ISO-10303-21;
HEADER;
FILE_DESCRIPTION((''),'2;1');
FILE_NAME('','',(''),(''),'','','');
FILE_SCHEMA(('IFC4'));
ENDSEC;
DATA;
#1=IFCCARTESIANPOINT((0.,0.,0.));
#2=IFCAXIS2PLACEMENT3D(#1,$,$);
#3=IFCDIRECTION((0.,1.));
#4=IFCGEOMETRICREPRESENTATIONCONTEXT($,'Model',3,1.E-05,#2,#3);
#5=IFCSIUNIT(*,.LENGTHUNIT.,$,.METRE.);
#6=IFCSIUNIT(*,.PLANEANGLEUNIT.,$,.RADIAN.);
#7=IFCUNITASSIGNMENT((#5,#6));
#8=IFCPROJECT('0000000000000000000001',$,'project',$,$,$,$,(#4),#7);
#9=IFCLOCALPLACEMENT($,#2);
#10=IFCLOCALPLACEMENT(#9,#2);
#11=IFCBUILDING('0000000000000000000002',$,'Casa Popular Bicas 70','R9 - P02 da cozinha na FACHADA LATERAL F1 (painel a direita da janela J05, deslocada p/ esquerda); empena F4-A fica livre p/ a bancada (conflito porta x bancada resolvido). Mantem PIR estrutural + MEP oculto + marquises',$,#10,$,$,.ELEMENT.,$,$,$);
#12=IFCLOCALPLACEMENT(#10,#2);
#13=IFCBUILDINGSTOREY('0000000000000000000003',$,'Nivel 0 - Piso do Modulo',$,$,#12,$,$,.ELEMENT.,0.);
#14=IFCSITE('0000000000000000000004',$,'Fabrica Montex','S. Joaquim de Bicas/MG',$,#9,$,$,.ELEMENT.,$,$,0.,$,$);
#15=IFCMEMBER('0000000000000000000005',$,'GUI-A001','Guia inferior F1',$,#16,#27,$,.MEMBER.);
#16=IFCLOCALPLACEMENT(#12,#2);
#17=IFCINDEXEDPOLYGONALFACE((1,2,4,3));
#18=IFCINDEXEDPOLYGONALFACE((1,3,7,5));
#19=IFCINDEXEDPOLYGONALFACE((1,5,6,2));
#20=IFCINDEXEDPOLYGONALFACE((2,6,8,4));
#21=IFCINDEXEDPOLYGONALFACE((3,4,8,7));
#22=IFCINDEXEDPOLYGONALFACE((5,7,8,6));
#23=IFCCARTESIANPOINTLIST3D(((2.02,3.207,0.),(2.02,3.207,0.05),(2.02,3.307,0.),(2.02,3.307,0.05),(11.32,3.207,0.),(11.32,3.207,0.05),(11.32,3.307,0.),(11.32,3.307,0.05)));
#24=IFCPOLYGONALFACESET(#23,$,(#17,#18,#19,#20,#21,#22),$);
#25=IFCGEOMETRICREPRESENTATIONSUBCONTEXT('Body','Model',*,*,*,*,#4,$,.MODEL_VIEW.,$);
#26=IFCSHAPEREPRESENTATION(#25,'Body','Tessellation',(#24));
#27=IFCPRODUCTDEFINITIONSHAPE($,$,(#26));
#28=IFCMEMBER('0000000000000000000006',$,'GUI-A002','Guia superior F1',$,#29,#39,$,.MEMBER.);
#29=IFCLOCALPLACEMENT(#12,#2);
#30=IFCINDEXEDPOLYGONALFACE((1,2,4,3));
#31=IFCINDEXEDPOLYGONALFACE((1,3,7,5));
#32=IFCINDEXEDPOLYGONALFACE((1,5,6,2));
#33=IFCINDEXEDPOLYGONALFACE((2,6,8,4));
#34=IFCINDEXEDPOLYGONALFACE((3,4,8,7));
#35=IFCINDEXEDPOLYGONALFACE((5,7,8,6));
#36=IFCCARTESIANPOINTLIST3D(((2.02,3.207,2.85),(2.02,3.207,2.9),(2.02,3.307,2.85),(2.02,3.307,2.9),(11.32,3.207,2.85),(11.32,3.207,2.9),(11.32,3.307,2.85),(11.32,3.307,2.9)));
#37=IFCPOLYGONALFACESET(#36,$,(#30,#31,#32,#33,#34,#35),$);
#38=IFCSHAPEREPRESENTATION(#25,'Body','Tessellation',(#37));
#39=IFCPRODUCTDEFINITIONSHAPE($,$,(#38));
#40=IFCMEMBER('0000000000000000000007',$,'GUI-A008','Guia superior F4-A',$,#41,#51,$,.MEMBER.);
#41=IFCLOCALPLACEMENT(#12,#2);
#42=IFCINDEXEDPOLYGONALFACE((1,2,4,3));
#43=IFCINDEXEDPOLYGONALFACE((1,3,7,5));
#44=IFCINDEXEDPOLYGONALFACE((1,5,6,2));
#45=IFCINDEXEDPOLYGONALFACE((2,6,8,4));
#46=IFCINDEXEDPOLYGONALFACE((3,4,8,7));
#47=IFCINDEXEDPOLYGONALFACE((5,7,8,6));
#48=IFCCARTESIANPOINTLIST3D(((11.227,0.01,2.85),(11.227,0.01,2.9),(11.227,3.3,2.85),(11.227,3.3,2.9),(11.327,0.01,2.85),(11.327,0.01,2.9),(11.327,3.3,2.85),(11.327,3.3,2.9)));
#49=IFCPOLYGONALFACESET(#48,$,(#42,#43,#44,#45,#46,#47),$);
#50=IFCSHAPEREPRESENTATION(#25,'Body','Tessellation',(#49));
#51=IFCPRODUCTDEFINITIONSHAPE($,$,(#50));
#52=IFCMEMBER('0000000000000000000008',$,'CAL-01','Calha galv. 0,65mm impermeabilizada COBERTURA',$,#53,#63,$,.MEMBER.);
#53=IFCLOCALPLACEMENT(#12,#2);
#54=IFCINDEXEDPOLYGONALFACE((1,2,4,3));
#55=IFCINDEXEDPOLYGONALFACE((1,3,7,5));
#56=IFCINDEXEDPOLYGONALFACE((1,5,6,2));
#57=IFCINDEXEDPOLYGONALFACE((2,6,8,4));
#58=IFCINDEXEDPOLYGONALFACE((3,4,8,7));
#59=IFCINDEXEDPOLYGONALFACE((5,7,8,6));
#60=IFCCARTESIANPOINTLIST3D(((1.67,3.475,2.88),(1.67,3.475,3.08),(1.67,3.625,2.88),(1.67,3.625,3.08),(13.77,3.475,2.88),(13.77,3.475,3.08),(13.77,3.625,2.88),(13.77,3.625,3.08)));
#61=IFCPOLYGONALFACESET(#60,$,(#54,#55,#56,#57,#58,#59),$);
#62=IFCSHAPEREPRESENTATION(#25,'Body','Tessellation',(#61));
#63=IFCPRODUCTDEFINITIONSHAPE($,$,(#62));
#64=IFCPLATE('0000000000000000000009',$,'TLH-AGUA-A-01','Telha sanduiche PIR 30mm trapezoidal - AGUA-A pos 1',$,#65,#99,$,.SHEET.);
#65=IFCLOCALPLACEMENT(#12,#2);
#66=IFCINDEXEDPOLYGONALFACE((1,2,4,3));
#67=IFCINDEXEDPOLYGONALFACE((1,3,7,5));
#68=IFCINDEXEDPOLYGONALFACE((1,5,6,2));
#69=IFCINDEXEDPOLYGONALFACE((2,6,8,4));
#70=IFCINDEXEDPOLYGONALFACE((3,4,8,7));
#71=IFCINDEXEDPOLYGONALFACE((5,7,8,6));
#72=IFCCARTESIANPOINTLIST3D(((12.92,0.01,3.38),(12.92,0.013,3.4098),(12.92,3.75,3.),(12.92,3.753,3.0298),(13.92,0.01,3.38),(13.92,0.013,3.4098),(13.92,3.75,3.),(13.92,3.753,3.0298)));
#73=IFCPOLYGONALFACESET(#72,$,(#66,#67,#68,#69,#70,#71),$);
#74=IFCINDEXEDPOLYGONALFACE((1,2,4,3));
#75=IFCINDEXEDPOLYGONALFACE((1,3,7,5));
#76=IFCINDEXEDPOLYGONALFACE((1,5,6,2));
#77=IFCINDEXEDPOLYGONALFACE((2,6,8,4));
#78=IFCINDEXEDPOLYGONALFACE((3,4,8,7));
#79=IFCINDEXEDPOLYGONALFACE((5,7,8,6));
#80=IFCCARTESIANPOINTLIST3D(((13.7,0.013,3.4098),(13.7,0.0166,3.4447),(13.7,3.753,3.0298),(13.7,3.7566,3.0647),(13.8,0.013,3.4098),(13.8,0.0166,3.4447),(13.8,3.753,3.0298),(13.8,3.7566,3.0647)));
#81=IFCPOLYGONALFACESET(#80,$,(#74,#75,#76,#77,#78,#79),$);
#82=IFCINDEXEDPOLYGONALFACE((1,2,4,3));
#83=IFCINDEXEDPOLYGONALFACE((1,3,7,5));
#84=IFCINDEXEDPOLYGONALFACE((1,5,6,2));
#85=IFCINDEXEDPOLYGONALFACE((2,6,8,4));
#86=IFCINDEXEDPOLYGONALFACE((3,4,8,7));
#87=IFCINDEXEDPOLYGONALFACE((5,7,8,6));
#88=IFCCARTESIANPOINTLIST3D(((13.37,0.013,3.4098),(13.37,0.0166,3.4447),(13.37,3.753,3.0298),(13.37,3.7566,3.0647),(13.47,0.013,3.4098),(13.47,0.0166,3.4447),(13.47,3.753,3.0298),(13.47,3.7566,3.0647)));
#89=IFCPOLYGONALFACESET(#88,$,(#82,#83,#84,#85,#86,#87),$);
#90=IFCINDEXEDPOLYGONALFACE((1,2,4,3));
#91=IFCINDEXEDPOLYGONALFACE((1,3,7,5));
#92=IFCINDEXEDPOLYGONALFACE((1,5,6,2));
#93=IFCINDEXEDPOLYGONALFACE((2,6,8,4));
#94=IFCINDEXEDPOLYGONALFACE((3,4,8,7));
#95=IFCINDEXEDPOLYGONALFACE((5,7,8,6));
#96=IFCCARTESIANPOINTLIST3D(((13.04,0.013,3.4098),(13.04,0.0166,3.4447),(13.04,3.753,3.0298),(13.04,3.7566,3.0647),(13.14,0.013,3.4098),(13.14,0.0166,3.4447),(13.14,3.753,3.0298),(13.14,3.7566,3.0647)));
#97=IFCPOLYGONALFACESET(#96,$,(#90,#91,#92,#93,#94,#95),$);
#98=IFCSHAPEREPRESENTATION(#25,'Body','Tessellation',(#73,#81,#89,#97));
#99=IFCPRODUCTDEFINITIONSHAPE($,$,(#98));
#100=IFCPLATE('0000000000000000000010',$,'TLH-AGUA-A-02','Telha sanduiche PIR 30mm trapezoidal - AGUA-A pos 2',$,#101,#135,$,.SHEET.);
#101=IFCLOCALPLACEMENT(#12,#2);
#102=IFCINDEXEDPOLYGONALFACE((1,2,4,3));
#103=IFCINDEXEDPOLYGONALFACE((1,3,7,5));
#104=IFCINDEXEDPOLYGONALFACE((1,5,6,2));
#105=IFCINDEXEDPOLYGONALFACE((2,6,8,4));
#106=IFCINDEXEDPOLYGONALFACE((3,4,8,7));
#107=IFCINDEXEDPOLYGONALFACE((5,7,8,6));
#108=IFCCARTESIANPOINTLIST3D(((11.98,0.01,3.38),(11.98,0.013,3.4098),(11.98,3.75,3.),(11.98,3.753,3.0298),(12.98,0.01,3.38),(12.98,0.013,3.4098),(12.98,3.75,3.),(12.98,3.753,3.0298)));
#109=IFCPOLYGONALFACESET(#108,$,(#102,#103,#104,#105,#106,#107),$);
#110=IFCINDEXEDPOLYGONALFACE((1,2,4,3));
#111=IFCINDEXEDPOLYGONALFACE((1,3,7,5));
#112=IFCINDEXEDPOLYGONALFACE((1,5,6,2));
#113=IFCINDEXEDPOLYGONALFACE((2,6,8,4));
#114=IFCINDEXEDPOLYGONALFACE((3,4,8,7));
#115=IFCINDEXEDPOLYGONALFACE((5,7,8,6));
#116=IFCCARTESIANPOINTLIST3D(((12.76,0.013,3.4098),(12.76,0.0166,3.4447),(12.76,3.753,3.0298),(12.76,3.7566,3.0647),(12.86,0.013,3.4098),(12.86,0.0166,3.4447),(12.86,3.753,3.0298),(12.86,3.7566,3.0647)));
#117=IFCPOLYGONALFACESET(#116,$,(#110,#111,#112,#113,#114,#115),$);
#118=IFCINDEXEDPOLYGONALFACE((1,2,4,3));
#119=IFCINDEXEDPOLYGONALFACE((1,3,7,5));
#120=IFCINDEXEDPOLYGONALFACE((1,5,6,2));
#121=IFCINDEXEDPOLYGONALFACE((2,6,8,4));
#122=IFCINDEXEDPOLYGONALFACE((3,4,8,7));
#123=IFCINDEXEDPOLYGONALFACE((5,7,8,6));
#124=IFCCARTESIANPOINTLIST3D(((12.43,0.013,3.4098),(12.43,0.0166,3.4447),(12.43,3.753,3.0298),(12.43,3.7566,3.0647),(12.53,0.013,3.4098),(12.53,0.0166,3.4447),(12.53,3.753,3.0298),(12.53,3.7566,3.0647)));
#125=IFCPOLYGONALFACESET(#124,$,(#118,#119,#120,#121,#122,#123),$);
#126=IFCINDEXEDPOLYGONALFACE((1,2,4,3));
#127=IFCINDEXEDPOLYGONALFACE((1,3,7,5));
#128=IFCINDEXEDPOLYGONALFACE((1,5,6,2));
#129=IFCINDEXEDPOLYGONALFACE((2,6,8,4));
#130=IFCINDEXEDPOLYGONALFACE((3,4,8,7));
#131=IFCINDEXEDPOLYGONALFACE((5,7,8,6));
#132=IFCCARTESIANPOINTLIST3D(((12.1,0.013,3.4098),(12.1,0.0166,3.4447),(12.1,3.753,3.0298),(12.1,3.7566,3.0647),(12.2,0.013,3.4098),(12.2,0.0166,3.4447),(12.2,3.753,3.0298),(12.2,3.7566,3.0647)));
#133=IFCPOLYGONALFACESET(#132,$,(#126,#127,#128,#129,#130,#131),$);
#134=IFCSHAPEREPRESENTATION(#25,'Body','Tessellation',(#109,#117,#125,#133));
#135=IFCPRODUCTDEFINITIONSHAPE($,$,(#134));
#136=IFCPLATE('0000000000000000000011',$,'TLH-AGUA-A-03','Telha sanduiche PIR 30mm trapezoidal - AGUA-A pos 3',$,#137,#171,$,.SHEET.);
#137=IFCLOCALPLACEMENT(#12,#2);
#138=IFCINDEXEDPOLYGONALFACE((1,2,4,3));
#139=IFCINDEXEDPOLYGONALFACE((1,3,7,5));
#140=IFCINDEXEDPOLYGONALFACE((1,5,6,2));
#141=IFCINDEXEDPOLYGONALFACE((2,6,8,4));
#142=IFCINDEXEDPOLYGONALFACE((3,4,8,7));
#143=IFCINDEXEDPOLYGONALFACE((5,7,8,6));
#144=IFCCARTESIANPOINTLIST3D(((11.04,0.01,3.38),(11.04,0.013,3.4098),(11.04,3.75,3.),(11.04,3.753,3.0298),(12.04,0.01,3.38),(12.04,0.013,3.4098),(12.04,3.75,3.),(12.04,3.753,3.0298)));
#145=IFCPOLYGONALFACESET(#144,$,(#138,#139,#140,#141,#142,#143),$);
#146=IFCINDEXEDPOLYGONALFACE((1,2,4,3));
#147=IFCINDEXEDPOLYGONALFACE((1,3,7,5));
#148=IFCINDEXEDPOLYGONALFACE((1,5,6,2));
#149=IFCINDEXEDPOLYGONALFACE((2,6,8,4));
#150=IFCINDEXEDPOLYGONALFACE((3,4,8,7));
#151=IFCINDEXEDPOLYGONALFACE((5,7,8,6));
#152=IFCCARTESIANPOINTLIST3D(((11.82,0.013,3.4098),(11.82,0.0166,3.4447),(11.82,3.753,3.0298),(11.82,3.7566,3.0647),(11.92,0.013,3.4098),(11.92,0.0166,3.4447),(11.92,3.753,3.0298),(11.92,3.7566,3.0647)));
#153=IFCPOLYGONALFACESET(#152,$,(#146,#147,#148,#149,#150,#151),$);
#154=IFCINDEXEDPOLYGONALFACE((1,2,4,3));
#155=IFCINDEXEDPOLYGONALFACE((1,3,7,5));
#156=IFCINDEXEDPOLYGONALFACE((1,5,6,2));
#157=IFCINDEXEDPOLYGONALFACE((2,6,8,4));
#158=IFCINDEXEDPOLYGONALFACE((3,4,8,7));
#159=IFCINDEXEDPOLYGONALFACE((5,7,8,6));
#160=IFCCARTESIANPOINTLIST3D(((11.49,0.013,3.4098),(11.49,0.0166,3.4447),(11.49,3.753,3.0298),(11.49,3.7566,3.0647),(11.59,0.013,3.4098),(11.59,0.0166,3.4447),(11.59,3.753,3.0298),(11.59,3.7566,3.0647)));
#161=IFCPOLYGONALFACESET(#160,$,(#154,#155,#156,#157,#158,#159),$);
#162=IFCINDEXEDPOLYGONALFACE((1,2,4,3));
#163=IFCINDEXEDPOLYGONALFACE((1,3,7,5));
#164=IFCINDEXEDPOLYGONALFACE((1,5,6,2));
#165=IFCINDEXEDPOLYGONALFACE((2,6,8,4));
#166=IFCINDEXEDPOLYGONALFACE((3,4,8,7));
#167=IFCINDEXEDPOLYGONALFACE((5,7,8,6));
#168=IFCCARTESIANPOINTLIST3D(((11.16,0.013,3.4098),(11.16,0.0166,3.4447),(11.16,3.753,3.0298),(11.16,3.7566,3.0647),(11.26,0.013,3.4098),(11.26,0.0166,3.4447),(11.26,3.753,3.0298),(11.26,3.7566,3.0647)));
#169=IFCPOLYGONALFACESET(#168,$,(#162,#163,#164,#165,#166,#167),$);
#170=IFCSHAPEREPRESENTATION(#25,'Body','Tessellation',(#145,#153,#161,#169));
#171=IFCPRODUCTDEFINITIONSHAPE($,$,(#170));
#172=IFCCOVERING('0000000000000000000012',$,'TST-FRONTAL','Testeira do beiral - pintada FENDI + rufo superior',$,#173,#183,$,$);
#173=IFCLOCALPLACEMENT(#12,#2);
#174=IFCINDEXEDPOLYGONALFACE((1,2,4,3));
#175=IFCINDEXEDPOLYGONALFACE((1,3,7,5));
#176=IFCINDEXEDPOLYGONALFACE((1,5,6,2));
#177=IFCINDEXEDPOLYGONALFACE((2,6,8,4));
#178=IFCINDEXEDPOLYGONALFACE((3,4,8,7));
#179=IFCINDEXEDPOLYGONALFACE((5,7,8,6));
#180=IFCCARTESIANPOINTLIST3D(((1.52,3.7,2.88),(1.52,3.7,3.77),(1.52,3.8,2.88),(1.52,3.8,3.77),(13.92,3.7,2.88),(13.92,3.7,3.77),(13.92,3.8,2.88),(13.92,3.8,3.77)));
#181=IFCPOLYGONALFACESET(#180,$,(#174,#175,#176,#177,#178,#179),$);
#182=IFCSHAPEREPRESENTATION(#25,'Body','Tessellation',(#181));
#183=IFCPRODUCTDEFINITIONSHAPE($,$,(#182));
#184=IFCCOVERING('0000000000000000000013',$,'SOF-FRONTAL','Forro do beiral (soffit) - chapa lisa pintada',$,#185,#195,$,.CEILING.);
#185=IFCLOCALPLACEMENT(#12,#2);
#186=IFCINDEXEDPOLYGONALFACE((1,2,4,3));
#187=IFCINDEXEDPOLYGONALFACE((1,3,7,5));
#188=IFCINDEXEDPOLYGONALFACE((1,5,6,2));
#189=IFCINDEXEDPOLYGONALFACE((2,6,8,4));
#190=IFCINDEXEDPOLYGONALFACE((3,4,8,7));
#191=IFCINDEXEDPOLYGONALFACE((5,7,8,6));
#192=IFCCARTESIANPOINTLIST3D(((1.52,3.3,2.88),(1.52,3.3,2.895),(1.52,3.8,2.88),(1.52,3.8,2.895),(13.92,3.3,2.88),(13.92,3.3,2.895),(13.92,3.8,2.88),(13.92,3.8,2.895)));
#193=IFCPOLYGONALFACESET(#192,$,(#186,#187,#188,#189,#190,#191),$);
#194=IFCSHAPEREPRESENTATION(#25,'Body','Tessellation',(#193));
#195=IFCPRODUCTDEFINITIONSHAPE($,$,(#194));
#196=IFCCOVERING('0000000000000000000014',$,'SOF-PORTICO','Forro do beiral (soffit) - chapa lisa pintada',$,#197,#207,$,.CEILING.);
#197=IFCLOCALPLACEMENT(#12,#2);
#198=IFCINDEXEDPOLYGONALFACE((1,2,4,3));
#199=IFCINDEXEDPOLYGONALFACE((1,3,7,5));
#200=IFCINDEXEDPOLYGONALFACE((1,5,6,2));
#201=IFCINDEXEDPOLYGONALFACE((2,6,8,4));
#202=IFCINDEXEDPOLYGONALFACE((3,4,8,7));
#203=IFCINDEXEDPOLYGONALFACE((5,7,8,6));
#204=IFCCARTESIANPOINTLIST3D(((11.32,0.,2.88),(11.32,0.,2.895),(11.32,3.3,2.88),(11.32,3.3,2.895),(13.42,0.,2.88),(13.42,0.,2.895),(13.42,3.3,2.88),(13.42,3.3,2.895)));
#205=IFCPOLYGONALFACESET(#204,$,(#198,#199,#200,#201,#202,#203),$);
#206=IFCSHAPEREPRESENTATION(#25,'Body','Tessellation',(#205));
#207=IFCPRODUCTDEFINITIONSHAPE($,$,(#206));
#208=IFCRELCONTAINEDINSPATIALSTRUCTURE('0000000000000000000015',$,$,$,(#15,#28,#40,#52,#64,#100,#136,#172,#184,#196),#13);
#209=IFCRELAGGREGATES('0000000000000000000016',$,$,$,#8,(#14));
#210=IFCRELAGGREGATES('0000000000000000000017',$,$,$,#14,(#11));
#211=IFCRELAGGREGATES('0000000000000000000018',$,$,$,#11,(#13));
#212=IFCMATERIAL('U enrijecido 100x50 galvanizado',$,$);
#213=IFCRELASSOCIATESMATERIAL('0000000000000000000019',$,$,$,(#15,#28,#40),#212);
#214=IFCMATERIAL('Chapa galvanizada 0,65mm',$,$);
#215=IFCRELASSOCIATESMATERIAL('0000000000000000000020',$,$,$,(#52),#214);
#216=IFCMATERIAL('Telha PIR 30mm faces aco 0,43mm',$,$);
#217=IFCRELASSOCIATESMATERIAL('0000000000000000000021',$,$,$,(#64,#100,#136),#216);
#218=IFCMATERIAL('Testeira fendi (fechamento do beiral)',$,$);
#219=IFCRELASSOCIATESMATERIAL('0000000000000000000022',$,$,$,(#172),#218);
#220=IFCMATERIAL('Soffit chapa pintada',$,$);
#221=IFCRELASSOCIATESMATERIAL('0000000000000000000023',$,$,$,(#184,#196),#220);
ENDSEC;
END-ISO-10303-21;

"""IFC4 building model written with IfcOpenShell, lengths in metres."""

from ifc_helpers import new_model, si_unit, direction, frame, frame_2d, origin, origin_2d, place, context, subcontext, project, spatial, rectangle, extrude, material, element, save


model = new_model("IFC4")

# Units and contexts
model_context = context("Model", 3, precision=1e-05, world=origin(), true_north=direction((0.0, 1.0)))
body_context = subcontext(model_context, "Body", "Model", "MODEL_VIEW")
ifc_project = project(units=[si_unit("LENGTHUNIT", "METRE"), si_unit("PLANEANGLEUNIT", "RADIAN")], contexts=[model_context])

# Site, building, storey
site_placement = place(None, origin())
site = spatial("IfcSite", under=ifc_project, at=site_placement, Name="Fabrica Montex", Description="S. Joaquim de Bicas/MG", CompositionType="ELEMENT", RefElevation=0.0)
building_placement = place(site_placement, origin())
building = spatial("IfcBuilding", under=site, at=building_placement, Name="Casa Popular Bicas 70", Description="R9 - P02 da cozinha na FACHADA LATERAL F1 (painel a direita da janela J05, deslocada p/ esquerda); empena F4-A fica livre p/ a bancada (conflito porta x bancada resolvido). Mantem PIR estrutural + MEP oculto + marquises", CompositionType="ELEMENT")
storey_placement = place(building_placement, origin())
storey = spatial("IfcBuildingStorey", under=building, at=storey_placement, Name="Nivel 0 - Piso do Modulo", CompositionType="ELEMENT", Elevation=0.0)

# Members
ifc_material_1 = material(Name="U enrijecido 100x50 galvanizado")
for number, where, z_axis, x_axis, name, description in (
    (1, (11.32, 3.257, 0.025), (-1.0, 0.0, 0.0), (0.0, 0.0, 1.0), "GUI-A001", "Guia inferior F1"),
    (2, (11.32, 3.257, 2.875), (-1.0, 0.0, 0.0), (0.0, 0.0, 1.0), "GUI-A002", "Guia superior F1"),
):
    element("IfcMember", number, at=place(None, frame(where, z_axis=z_axis, x_axis=x_axis)), inside=storey, material=ifc_material_1, Name=name, Description=description, PredefinedType="MEMBER", context=body_context, shape_type="SweptSolid", body=[
        extrude(rectangle(XDim=0.05, YDim=0.1, at=origin_2d()), origin(), (0.0, 0.0, 1.0), 9.3),
    ])
member_1_placement = place(None, frame((11.277, 3.3, 2.875), z_axis=(0.0, -1.0, 0.0), x_axis=(0.0, 0.0, 1.0)))
element("IfcMember", 3, at=member_1_placement, inside=storey, material=ifc_material_1, Name="GUI-A008", Description="Guia superior F4-A", PredefinedType="MEMBER", context=body_context, shape_type="SweptSolid", body=[
    extrude(rectangle(XDim=0.05, YDim=0.1, at=origin_2d()), origin(), (0.0, 0.0, 1.0), 3.29),
])
ifc_material_2 = material(Name="Chapa galvanizada 0,65mm")
member_2_placement = place(None, frame((13.77, 3.55, 2.98), z_axis=(-1.0, 0.0, 0.0), x_axis=(0.0, 0.0, 1.0)))
element("IfcMember", 4, at=member_2_placement, inside=storey, material=ifc_material_2, Name="CAL-01", Description="Calha galv. 0,65mm impermeabilizada COBERTURA", PredefinedType="MEMBER", context=body_context, shape_type="SweptSolid", body=[
    extrude(rectangle(XDim=0.2, YDim=0.15, at=origin_2d()), origin(), (0.0, 0.0, 1.0), 12.1),
])

# Plates
ifc_material_3 = material(Name="Telha PIR 30mm faces aco 0,43mm")
for number, where, z_axis, x_axis, name, description in (
    (5, (13.92, 3.75, 3.0), (0.0, 0.101084, 0.994878), (-1.0, 0.0, 0.0), "TLH-AGUA-A-01", "Telha sanduiche PIR 30mm trapezoidal - AGUA-A pos 1"),
    (6, (12.98, 3.75, 3.0), (0.0, 0.101084, 0.994878), (-1.0, 0.0, 0.0), "TLH-AGUA-A-02", "Telha sanduiche PIR 30mm trapezoidal - AGUA-A pos 2"),
    (7, (12.04, 3.75, 3.0), (0.0, 0.101084, 0.994878), (-1.0, 0.0, 0.0), "TLH-AGUA-A-03", "Telha sanduiche PIR 30mm trapezoidal - AGUA-A pos 3"),
):
    element("IfcPlate", number, at=place(None, frame(where, z_axis=z_axis, x_axis=x_axis)), inside=storey, material=ifc_material_3, Name=name, Description=description, PredefinedType="SHEET", context=body_context, shape_type="SweptSolid", body=[
        extrude(rectangle(XDim=1.0, YDim=3.7593, at=frame_2d((0.5, 1.8796))), origin(), (0.0, 0.0, 1.0), 0.03),
        extrude(rectangle(XDim=0.1, YDim=3.7593, at=frame_2d((0.17, 1.8796))), frame((0.0, 0.0, 0.03)), (0.0, 0.0, 1.0), 0.035),
        extrude(rectangle(XDim=0.1, YDim=3.7593, at=frame_2d((0.5, 1.8796))), frame((0.0, 0.0, 0.03)), (0.0, 0.0, 1.0), 0.035),
        extrude(rectangle(XDim=0.1, YDim=3.7593, at=frame_2d((0.83, 1.8796))), frame((0.0, 0.0, 0.03)), (0.0, 0.0, 1.0), 0.035),
    ])

# Coverings
ifc_material_4 = material(Name="Testeira fendi (fechamento do beiral)")
covering_1_placement = place(None, frame((13.92, 3.75, 2.88), z_axis=(0.0, 0.0, 1.0), x_axis=(-1.0, 0.0, 0.0)))
element("IfcCovering", 8, at=covering_1_placement, inside=storey, material=ifc_material_4, Name="TST-FRONTAL", Description="Testeira do beiral - pintada FENDI + rufo superior", context=body_context, shape_type="SweptSolid", body=[
    extrude(rectangle(XDim=12.4, YDim=0.1, at=frame_2d((6.2, 0.0))), origin(), (0.0, 0.0, 1.0), 0.89),
])
ifc_material_5 = material(Name="Soffit chapa pintada")
covering_2_placement = place(None, frame((13.92, 3.8, 2.88), z_axis=(0.0, 0.0, 1.0), x_axis=(-1.0, 0.0, 0.0)))
element("IfcCovering", 9, at=covering_2_placement, inside=storey, material=ifc_material_5, Name="SOF-FRONTAL", Description="Forro do beiral (soffit) - chapa lisa pintada", PredefinedType="CEILING", context=body_context, shape_type="SweptSolid", body=[
    extrude(rectangle(XDim=12.4, YDim=0.5, at=frame_2d((6.2, 0.25))), origin(), (0.0, 0.0, 1.0), 0.015),
])
covering_3_placement = place(None, frame((13.42, 3.3, 2.88), z_axis=(0.0, 0.0, 1.0), x_axis=(-1.0, 0.0, 0.0)))
element("IfcCovering", 10, at=covering_3_placement, inside=storey, material=ifc_material_5, Name="SOF-PORTICO", Description="Forro do beiral (soffit) - chapa lisa pintada", PredefinedType="CEILING", context=body_context, shape_type="SweptSolid", body=[
    extrude(rectangle(XDim=2.1, YDim=3.3, at=frame_2d((1.05, 1.65))), origin(), (0.0, 0.0, 1.0), 0.015),
])

save(model, "model.ifc")
